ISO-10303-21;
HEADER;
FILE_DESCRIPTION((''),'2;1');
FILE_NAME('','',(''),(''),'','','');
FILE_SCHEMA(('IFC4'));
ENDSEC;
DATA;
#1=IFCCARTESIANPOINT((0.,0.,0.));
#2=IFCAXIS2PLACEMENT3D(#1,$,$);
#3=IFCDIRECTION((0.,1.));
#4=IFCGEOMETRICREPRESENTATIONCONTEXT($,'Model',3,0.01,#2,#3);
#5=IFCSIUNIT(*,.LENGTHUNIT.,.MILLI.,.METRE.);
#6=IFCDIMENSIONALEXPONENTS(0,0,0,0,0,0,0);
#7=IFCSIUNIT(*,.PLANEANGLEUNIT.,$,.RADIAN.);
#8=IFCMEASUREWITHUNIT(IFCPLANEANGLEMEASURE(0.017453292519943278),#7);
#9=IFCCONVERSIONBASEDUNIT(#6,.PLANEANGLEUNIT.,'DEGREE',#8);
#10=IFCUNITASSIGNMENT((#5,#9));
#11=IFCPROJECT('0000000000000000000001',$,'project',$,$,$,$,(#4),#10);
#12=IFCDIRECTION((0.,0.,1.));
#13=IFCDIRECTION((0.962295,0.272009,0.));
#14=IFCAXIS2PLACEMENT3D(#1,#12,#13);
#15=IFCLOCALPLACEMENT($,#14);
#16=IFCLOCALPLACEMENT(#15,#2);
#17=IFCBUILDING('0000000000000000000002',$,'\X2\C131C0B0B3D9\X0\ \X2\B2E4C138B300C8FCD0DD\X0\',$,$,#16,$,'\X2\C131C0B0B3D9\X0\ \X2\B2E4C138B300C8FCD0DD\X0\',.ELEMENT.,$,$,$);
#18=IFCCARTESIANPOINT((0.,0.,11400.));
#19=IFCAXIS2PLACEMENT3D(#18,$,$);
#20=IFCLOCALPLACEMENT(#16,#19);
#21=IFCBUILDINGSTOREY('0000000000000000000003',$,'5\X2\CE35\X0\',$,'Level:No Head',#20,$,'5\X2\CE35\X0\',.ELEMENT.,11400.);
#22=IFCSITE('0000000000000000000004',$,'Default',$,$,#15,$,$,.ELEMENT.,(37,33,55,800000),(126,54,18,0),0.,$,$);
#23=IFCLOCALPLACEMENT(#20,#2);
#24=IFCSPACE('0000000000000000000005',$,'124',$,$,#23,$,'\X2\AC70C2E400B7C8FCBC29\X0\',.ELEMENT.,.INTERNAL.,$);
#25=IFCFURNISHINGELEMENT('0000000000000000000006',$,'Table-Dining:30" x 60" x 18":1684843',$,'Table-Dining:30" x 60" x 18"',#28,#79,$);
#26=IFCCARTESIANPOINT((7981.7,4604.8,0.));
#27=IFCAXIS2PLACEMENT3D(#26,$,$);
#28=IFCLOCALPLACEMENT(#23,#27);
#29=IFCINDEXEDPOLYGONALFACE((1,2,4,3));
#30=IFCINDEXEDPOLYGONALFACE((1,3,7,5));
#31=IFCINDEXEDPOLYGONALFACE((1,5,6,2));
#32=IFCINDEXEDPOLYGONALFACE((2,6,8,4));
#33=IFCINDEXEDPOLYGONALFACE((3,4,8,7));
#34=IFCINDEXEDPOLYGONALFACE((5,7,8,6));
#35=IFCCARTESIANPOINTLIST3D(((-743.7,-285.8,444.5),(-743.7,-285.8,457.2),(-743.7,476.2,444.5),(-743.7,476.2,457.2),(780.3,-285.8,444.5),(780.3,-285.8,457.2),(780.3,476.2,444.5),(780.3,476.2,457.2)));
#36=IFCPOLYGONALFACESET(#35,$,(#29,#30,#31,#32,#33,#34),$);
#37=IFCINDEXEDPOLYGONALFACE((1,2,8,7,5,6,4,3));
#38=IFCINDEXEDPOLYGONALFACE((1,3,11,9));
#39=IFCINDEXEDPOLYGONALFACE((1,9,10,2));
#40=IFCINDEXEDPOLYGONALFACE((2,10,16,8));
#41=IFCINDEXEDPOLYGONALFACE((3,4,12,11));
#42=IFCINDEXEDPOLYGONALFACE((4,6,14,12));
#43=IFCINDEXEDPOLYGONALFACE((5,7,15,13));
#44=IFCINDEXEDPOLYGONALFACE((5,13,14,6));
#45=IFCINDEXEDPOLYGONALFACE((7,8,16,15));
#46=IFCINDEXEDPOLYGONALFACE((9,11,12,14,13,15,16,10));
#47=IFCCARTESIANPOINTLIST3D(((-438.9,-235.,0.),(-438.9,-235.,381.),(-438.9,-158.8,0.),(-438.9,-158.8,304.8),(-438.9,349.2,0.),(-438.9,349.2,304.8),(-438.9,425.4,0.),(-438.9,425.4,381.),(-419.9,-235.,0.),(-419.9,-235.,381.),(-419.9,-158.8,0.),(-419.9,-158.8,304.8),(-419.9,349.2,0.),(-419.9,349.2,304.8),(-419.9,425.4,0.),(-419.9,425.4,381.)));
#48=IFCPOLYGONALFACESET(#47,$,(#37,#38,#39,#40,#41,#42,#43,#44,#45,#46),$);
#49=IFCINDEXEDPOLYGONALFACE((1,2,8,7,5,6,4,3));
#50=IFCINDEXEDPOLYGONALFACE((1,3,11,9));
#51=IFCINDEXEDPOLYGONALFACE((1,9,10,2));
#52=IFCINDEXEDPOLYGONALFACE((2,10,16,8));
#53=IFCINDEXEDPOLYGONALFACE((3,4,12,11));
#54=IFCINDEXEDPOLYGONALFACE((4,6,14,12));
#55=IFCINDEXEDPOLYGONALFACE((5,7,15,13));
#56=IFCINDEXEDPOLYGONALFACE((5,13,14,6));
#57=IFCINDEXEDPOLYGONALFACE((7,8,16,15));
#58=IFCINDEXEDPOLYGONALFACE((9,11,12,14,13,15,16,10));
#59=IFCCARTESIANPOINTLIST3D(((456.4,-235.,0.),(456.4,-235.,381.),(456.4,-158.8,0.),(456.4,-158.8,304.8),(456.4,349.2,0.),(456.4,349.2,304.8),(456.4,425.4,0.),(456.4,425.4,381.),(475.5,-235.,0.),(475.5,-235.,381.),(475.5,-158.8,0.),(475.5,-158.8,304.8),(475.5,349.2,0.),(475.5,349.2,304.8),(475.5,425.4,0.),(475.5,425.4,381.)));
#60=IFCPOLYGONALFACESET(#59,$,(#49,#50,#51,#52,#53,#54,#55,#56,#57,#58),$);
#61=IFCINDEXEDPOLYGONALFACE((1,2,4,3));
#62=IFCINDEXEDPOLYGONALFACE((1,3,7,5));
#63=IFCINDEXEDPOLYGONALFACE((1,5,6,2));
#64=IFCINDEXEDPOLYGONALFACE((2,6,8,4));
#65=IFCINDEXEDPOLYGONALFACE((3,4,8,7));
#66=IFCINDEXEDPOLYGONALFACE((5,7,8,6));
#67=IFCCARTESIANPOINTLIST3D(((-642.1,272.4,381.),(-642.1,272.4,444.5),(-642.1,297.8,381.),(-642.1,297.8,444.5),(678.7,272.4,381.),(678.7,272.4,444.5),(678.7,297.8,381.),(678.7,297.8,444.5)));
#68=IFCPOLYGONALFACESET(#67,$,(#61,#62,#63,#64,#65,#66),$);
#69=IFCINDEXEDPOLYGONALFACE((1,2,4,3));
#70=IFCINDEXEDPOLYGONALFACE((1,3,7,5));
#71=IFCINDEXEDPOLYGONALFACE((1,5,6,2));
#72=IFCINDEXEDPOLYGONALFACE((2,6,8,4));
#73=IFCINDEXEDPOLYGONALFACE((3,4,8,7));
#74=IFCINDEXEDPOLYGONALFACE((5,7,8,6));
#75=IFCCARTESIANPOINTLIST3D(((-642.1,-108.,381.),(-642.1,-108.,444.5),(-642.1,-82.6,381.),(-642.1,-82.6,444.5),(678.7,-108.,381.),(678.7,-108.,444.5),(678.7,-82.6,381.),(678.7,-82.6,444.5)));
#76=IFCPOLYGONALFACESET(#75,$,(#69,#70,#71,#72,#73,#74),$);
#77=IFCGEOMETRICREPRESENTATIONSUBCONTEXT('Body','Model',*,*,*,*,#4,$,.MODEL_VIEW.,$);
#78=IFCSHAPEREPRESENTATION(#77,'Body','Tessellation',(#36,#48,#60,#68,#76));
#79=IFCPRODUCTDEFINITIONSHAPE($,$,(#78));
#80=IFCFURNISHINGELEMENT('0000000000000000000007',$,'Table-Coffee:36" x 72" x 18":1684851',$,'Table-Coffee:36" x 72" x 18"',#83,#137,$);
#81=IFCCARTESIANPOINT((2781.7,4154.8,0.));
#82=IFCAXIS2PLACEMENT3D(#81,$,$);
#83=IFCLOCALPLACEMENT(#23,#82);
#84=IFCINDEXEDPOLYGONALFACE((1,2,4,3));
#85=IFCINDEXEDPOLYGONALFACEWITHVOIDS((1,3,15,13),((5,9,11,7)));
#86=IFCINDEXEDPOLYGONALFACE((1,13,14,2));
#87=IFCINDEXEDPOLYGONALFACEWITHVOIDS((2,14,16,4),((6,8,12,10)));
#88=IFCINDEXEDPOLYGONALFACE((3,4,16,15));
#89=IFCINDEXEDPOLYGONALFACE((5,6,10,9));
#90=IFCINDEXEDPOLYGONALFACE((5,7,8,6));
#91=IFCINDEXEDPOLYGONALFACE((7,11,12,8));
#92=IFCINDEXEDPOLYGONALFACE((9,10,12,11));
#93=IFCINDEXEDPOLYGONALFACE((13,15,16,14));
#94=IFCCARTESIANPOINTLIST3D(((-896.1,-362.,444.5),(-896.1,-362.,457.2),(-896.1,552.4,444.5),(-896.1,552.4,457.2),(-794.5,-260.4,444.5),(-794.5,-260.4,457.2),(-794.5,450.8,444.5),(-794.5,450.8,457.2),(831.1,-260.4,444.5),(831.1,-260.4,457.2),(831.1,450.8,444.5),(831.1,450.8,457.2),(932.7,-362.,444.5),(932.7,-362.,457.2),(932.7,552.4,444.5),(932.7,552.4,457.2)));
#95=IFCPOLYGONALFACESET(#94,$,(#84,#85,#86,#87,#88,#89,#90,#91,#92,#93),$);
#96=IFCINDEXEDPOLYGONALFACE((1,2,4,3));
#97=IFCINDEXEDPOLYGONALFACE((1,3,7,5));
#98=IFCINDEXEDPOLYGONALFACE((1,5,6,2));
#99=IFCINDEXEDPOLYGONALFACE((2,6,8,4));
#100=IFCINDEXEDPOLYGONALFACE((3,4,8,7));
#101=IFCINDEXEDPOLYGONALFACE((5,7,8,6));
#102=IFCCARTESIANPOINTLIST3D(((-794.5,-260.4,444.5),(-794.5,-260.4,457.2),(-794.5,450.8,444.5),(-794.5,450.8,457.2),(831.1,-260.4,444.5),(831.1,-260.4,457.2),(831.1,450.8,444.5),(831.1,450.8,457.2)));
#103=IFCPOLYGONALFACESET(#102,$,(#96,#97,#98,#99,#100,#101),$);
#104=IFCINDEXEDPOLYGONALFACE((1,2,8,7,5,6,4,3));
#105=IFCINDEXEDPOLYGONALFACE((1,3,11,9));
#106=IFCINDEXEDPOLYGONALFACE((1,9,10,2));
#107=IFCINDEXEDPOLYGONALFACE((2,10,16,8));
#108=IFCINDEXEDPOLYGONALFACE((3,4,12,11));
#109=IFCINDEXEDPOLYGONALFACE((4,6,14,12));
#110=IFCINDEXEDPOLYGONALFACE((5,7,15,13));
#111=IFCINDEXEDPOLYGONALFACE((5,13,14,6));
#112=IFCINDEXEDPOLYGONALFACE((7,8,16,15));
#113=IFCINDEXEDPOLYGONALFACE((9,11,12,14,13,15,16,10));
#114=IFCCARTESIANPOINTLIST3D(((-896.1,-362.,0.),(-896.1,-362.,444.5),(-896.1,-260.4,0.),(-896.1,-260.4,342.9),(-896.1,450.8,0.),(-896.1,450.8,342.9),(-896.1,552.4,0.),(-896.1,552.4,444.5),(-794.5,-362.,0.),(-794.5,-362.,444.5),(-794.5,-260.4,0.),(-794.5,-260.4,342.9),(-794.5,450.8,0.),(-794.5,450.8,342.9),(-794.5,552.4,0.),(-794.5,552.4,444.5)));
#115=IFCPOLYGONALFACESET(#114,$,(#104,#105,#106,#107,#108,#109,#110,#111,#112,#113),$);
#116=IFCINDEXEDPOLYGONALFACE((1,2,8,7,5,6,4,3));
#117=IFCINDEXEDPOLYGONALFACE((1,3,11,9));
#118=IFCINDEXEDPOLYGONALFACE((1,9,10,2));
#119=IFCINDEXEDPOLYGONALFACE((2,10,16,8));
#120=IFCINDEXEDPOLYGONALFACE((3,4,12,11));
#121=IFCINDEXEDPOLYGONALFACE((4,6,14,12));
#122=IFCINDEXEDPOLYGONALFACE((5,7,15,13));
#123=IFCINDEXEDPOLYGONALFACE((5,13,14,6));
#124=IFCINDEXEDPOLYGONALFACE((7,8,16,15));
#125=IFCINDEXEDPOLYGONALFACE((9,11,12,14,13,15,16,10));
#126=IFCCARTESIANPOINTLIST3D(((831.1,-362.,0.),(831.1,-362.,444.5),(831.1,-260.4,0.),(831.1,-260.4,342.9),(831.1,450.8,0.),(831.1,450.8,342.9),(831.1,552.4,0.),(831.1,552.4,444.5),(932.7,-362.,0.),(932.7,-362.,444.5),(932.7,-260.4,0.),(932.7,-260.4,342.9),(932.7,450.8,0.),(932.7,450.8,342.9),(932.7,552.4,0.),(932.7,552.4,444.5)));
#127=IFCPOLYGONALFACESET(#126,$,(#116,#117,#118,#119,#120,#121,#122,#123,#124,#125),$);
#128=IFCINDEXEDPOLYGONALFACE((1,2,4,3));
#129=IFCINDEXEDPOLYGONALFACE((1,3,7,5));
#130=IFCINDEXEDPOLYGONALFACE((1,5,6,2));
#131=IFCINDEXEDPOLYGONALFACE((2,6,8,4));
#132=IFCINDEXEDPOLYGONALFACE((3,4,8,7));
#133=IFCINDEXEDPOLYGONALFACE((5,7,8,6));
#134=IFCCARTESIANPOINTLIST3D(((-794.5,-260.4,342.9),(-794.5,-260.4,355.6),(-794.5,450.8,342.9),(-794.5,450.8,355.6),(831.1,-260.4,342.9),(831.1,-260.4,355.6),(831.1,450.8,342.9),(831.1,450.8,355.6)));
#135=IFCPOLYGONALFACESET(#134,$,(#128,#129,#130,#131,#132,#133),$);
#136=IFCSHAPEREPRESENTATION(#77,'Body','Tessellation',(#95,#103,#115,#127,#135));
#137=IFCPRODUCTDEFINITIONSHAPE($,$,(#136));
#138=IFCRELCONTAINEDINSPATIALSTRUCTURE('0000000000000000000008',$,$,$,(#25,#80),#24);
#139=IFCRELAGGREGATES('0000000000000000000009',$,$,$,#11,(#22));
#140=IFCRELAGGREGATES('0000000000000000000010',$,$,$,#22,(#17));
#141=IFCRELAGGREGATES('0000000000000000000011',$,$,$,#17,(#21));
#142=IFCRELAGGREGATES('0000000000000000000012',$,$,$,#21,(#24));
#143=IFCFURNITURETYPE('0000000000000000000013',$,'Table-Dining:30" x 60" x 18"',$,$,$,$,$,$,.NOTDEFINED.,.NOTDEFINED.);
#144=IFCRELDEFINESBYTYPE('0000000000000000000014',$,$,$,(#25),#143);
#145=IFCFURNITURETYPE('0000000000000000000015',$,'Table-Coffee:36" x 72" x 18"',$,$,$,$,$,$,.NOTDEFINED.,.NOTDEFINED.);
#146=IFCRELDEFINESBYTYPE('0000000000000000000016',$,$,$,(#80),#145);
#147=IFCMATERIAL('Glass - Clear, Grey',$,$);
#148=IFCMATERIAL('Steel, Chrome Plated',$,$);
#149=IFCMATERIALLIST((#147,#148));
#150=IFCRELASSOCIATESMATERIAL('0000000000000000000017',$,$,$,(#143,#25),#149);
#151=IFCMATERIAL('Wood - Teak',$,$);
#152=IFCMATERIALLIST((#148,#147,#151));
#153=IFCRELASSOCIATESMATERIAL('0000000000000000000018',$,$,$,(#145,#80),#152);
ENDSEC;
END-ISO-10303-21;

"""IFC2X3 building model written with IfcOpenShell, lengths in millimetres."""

from ifc_helpers import new_model, entity, si_unit, converted_unit, direction, frame, frame_2d, origin, origin_2d_with_axis, place, context, subcontext, project, spatial, polyline, rectangle, outline, extrude, source, transform, mapped, material, material_list, type_object, type_shapes, element, save


model = new_model("IFC2X3")

# Units and contexts
model_context = context("Model", 3, precision=0.01, world=origin(), true_north=direction((0.0, 1.0)))
body_context = subcontext(model_context, "Body", "Model", "MODEL_VIEW")
ifc_project = project(units=[si_unit("LENGTHUNIT", "METRE", prefix="MILLI"), converted_unit("PLANEANGLEUNIT", "DEGREE", entity("IfcPlaneAngleMeasure", 0.017453292519943278), si_unit("PLANEANGLEUNIT", "RADIAN"), dimensions=[0, 0, 0, 0, 0, 0, 0])], contexts=[model_context])

# Site, building, storey
site_placement = place(None, frame((0.0, 0.0, 0.0), z_axis=(0.0, 0.0, 1.0), x_axis=(0.962295, 0.272009, 0.0)))
site = spatial("IfcSite", under=ifc_project, at=site_placement, Name="Default", CompositionType="ELEMENT", RefLatitude=(37, 33, 55, 800000), RefLongitude=(126, 54, 18, 0), RefElevation=0.0)
building_placement = place(site_placement, origin())
building = spatial("IfcBuilding", under=site, at=building_placement, Name="성산동 다세대주택", LongName="성산동 다세대주택", CompositionType="ELEMENT")
storey_placement = place(building_placement, frame((0.0, 0.0, 11400.0)))
storey = spatial("IfcBuildingStorey", under=building, at=storey_placement, Name="5층", ObjectType="Level:No Head", LongName="5층", CompositionType="ELEMENT", Elevation=11400.0)

# Shared definitions
space_1_placement = place(storey_placement, origin())
space_1 = spatial("IfcSpace", under=storey, at=space_1_placement, Name="124", LongName="거실·주방", CompositionType="ELEMENT", InteriorOrExteriorSpace="INTERNAL")

# Furnishing elements
ifc_material_1 = material(Name="Glass - Clear, Grey")
ifc_material_2 = material(Name="Steel, Chrome Plated")
ifc_material_list_1 = material_list([ifc_material_1, ifc_material_2])
furniture_type_1 = type_object("IfcFurnitureType", Name="Table-Dining:30\" x 60\" x 18\"", AssemblyPlace="NOTDEFINED", material=ifc_material_list_1)
shared_shape_1 = source(origin(), body_context, "Body", "SweptSolid", [
    extrude(rectangle(XDim=1524.0, YDim=762.0, at=frame_2d((0.0, 0.0), x_axis=(1.0, 0.0))), frame((18.3, 95.2, 444.5), z_axis=(0.0, 0.0, 1.0), x_axis=(-1.0, 0.0, 0.0)), (0.0, 0.0, 1.0), 12.7),
    extrude(outline(polyline([(-330.2, -209.5), (330.2, -209.5), (330.2, 171.4), (254.0, 171.4), (254.0, -133.3), (-254.0, -133.3), (-254.0, 171.4), (-330.2, 171.4), (-330.2, -209.5)])), frame((-438.9, 95.2, 171.4), z_axis=(1.0, 0.0, 0.0), x_axis=(0.0, -1.0, 0.0)), (0.0, 0.0, 1.0), 19.1),
    extrude(outline(polyline([(-171.4, -330.2), (209.5, -330.2), (209.5, 330.2), (-171.4, 330.2), (-171.4, 254.0), (133.3, 254.0), (133.3, -254.0), (-171.4, -254.0), (-171.4, -330.2)])), frame((456.4, 95.2, 171.4), z_axis=(1.0, 0.0, 0.0), x_axis=(0.0, 0.0, 1.0)), (0.0, 0.0, 1.0), 19.1),
    extrude(rectangle(XDim=1320.8, YDim=25.4, at=frame_2d((0.0, 0.0), x_axis=(1.0, 0.0))), frame((18.3, 285.1, 381.0), z_axis=(0.0, 0.0, 1.0), x_axis=(-1.0, 0.0, 0.0)), (0.0, 0.0, 1.0), 63.5),
    extrude(rectangle(XDim=1320.8, YDim=25.4, at=origin_2d_with_axis()), frame((18.3, -95.3, 381.0), z_axis=(0.0, 0.0, 1.0), x_axis=(-1.0, 0.0, 0.0)), (0.0, 0.0, 1.0), 63.5),
])
type_shapes(furniture_type_1, [shared_shape_1])
furnishing_1_placement = place(space_1_placement, frame((7981.7, 4604.8, 0.0)))
element("IfcFurnishingElement", 1, at=furnishing_1_placement, inside=space_1, type_object=furniture_type_1, material=ifc_material_list_1, Name="Table-Dining:30\" x 60\" x 18\":1684843", ObjectType="Table-Dining:30\" x 60\" x 18\"", context=body_context, shape_type="MappedRepresentation", body=[
    mapped(shared_shape_1, transform((0.0, 0.0, 0.0), scale=1.0)),
])
ifc_material_3 = material(Name="Wood - Teak")
ifc_material_list_2 = material_list([ifc_material_2, ifc_material_1, ifc_material_3])
furniture_type_2 = type_object("IfcFurnitureType", Name="Table-Coffee:36\" x 72\" x 18\"", AssemblyPlace="NOTDEFINED", material=ifc_material_list_2)
shared_shape_2 = source(origin(), body_context, "Body", "SweptSolid", [
    extrude(outline(polyline([(-914.4, -457.2), (914.4, -457.2), (914.4, 457.2), (-914.4, 457.2), (-914.4, -457.2)]), holes=[polyline([(-812.8, -355.6), (-812.8, 355.6), (812.8, 355.6), (812.8, -355.6), (-812.8, -355.6)])]), frame((18.3, 95.2, 444.5), z_axis=(0.0, 0.0, 1.0), x_axis=(-1.0, 0.0, 0.0)), (0.0, 0.0, 1.0), 12.7),
    extrude(rectangle(XDim=1625.6, YDim=711.2, at=origin_2d_with_axis()), frame((18.3, 95.2, 444.5), z_axis=(0.0, 0.0, 1.0), x_axis=(-1.0, 0.0, 0.0)), (0.0, 0.0, 1.0), 12.7),
    extrude(outline(polyline([(-457.2, -247.7), (457.2, -247.7), (457.2, 196.9), (355.6, 196.9), (355.6, -146.0), (-355.6, -146.0), (-355.6, 196.9), (-457.2, 196.9), (-457.2, -247.7)])), frame((-896.1, 95.2, 196.9), z_axis=(1.0, 0.0, 0.0), x_axis=(0.0, -1.0, 0.0)), (0.0, 0.0, 1.0), 101.6),
    extrude(outline(polyline([(-196.8, -457.2), (247.6, -457.2), (247.6, 457.2), (-196.8, 457.2), (-196.8, 355.6), (146.1, 355.6), (146.1, -355.6), (-196.8, -355.6), (-196.8, -457.2)])), frame((831.1, 95.2, 196.8), z_axis=(1.0, 0.0, 0.0), x_axis=(0.0, 0.0, 1.0)), (0.0, 0.0, 1.0), 101.6),
    extrude(rectangle(XDim=1625.6, YDim=711.2, at=origin_2d_with_axis()), frame((18.3, 95.2, 342.9), z_axis=(0.0, 0.0, 1.0), x_axis=(-1.0, 0.0, 0.0)), (0.0, 0.0, 1.0), 12.7),
])
type_shapes(furniture_type_2, [shared_shape_2])
furnishing_2_placement = place(space_1_placement, frame((2781.7, 4154.8, 0.0)))
element("IfcFurnishingElement", 2, at=furnishing_2_placement, inside=space_1, type_object=furniture_type_2, material=ifc_material_list_2, Name="Table-Coffee:36\" x 72\" x 18\":1684851", ObjectType="Table-Coffee:36\" x 72\" x 18\"", context=body_context, shape_type="MappedRepresentation", body=[
    mapped(shared_shape_2, transform((0.0, 0.0, 0.0), scale=1.0)),
])

save(model, "model.ifc")
